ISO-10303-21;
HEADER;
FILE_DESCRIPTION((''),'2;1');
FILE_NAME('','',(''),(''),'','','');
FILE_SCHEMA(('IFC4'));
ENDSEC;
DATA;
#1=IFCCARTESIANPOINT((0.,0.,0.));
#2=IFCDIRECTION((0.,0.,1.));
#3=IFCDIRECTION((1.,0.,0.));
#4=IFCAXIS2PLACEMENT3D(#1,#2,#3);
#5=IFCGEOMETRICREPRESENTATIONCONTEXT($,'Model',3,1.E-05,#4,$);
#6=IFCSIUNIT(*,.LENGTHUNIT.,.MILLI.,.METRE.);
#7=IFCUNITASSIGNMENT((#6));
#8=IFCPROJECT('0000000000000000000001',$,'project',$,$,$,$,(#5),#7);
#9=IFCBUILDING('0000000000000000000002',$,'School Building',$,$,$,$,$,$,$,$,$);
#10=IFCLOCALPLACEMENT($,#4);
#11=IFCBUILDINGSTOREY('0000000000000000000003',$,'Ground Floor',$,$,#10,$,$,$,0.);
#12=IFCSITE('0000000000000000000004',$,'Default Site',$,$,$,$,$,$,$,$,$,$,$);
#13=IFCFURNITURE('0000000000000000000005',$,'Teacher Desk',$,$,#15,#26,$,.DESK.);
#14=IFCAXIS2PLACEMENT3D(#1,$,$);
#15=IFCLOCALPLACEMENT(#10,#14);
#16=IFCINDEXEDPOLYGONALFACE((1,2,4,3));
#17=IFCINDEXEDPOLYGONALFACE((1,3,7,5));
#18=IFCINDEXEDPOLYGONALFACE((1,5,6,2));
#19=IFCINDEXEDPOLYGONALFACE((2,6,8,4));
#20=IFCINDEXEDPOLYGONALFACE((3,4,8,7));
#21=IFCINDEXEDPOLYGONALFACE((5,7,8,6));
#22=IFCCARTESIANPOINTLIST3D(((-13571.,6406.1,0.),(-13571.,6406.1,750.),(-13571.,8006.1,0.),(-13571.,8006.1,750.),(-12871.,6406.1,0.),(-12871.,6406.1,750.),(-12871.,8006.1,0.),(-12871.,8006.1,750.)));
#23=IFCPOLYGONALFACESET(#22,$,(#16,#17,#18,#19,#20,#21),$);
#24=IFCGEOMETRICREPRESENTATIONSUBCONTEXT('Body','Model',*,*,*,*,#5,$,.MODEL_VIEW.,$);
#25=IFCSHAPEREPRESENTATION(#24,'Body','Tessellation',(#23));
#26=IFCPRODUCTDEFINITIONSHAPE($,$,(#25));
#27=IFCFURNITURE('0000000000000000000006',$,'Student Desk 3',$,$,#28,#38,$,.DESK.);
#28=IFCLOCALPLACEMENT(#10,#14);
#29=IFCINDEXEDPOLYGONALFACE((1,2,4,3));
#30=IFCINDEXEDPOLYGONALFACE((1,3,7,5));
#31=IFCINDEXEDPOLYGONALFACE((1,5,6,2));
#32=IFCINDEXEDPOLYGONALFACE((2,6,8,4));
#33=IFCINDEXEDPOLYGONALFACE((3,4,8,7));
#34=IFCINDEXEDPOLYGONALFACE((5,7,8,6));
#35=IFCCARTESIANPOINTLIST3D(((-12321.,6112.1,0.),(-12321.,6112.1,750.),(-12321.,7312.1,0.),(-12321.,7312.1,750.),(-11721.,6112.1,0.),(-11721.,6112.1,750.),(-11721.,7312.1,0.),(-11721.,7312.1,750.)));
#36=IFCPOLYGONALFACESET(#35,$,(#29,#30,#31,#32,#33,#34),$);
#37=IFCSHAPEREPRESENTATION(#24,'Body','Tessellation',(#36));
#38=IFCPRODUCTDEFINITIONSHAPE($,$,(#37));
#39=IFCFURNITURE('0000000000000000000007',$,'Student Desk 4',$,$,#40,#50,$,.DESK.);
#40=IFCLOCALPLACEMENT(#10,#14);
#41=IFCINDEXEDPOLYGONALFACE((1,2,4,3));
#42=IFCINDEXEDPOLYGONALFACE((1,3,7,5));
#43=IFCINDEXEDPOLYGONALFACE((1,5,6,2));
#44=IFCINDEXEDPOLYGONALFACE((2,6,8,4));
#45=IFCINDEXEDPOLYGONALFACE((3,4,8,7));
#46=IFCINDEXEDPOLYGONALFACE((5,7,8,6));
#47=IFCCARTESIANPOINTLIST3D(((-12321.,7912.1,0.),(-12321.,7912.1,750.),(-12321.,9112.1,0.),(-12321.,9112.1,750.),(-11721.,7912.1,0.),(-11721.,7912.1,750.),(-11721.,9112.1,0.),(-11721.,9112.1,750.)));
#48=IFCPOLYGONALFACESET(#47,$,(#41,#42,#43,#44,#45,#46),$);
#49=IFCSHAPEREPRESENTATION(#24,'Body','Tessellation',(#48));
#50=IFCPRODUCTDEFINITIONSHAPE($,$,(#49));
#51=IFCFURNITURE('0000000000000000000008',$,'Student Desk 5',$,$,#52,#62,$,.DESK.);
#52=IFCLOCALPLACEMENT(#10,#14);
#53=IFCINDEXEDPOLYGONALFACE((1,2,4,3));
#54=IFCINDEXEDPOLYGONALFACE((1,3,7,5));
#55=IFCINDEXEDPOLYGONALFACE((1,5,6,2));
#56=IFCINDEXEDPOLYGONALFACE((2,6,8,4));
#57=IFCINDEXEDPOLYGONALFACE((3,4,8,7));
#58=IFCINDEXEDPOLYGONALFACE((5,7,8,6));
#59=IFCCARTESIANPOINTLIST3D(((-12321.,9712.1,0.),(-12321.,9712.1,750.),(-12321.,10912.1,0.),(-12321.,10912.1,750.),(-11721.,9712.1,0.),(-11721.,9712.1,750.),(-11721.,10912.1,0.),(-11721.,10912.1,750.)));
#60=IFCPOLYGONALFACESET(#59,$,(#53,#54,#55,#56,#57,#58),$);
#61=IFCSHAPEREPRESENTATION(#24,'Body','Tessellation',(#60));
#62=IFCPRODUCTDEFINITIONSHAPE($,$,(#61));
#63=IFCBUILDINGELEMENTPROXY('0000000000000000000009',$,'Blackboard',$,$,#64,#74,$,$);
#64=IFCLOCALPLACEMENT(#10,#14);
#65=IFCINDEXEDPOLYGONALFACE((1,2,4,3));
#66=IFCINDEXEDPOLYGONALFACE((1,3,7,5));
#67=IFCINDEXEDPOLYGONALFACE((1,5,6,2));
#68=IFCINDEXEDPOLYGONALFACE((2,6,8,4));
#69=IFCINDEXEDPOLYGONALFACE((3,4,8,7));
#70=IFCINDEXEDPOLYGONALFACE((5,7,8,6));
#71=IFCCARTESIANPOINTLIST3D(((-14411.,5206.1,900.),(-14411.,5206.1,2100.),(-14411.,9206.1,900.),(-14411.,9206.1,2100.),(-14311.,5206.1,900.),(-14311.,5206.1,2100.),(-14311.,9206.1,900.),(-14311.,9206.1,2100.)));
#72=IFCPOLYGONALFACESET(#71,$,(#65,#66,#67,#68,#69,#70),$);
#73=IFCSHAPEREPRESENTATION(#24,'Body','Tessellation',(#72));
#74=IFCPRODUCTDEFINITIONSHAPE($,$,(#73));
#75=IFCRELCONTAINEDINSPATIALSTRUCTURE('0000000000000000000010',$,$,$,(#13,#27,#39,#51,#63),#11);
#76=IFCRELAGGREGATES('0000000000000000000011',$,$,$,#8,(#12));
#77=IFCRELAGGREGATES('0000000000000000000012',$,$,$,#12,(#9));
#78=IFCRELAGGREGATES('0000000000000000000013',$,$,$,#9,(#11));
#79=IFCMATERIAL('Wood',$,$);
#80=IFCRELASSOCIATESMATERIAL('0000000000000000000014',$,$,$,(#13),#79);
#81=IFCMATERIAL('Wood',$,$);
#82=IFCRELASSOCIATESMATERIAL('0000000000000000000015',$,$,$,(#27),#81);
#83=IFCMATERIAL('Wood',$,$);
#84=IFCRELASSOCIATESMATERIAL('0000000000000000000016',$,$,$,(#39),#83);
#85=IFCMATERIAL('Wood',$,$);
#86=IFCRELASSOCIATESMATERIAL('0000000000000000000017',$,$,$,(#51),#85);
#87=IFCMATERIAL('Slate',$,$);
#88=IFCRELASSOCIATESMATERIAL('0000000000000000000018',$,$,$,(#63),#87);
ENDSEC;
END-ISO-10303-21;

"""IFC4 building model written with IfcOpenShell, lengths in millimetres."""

from ifc_helpers import new_model, si_unit, frame, origin_with_axes, origin_2d, place, context, subcontext, project, spatial, rectangle, extrude, material, element, save


model = new_model("IFC4")

# Units and contexts
model_context = context("Model", 3, precision=1e-05, world=origin_with_axes())
body_context = subcontext(model_context, "Body", "Model", "MODEL_VIEW")
ifc_project = project(units=[si_unit("LENGTHUNIT", "METRE", prefix="MILLI")], contexts=[model_context])

# Site, building, storey
site = spatial("IfcSite", under=ifc_project, Name="Default Site")
building = spatial("IfcBuilding", under=site, Name="School Building")
storey_placement = place(None, origin_with_axes())
storey = spatial("IfcBuildingStorey", under=building, at=storey_placement, Name="Ground Floor", Elevation=0.0)

# Furniture
ifc_material_1 = material(Name="Wood")
furniture_1_placement = place(storey_placement, frame((-13221.0, 7206.1, 0.0), z_axis=(0.0, 0.0, 1.0), x_axis=(0.0, 1.0, 0.0)))
element("IfcFurniture", 1, at=furniture_1_placement, inside=storey, material=ifc_material_1, Name="Teacher Desk", PredefinedType="DESK", context=body_context, shape_type="SweptSolid", body=[
    extrude(rectangle(XDim=1600.0, YDim=700.0, at=origin_2d()), origin_with_axes(), (0.0, 0.0, 1.0), 750.0),
])
ifc_material_2 = material(Name="Wood")
furniture_2_placement = place(storey_placement, frame((-12021.0, 6712.1, 0.0), z_axis=(0.0, 0.0, 1.0), x_axis=(0.0, 1.0, 0.0)))
element("IfcFurniture", 2, at=furniture_2_placement, inside=storey, material=ifc_material_2, Name="Student Desk 3", PredefinedType="DESK", context=body_context, shape_type="SweptSolid", body=[
    extrude(rectangle(XDim=1200.0, YDim=600.0, at=origin_2d()), origin_with_axes(), (0.0, 0.0, 1.0), 750.0),
])
ifc_material_3 = material(Name="Wood")
furniture_3_placement = place(storey_placement, frame((-12021.0, 8512.1, 0.0), z_axis=(0.0, 0.0, 1.0), x_axis=(0.0, 1.0, 0.0)))
element("IfcFurniture", 3, at=furniture_3_placement, inside=storey, material=ifc_material_3, Name="Student Desk 4", PredefinedType="DESK", context=body_context, shape_type="SweptSolid", body=[
    extrude(rectangle(XDim=1200.0, YDim=600.0, at=origin_2d()), origin_with_axes(), (0.0, 0.0, 1.0), 750.0),
])
ifc_material_4 = material(Name="Wood")
furniture_4_placement = place(storey_placement, frame((-12021.0, 10312.1, 0.0), z_axis=(0.0, 0.0, 1.0), x_axis=(0.0, 1.0, 0.0)))
element("IfcFurniture", 4, at=furniture_4_placement, inside=storey, material=ifc_material_4, Name="Student Desk 5", PredefinedType="DESK", context=body_context, shape_type="SweptSolid", body=[
    extrude(rectangle(XDim=1200.0, YDim=600.0, at=origin_2d()), origin_with_axes(), (0.0, 0.0, 1.0), 750.0),
])

# Building element proxy
ifc_material_5 = material(Name="Slate")
proxy_placement = place(storey_placement, frame((-14361.0, 7206.1, 900.0), z_axis=(0.0, 0.0, 1.0), x_axis=(1.0, 0.0, 0.0)))
element("IfcBuildingElementProxy", 5, at=proxy_placement, inside=storey, material=ifc_material_5, Name="Blackboard", context=body_context, shape_type="SweptSolid", body=[
    extrude(rectangle(XDim=100.0, YDim=4000.0, at=origin_2d()), origin_with_axes(), (0.0, 0.0, 1.0), 1200.0),
])

save(model, "model.ifc")
